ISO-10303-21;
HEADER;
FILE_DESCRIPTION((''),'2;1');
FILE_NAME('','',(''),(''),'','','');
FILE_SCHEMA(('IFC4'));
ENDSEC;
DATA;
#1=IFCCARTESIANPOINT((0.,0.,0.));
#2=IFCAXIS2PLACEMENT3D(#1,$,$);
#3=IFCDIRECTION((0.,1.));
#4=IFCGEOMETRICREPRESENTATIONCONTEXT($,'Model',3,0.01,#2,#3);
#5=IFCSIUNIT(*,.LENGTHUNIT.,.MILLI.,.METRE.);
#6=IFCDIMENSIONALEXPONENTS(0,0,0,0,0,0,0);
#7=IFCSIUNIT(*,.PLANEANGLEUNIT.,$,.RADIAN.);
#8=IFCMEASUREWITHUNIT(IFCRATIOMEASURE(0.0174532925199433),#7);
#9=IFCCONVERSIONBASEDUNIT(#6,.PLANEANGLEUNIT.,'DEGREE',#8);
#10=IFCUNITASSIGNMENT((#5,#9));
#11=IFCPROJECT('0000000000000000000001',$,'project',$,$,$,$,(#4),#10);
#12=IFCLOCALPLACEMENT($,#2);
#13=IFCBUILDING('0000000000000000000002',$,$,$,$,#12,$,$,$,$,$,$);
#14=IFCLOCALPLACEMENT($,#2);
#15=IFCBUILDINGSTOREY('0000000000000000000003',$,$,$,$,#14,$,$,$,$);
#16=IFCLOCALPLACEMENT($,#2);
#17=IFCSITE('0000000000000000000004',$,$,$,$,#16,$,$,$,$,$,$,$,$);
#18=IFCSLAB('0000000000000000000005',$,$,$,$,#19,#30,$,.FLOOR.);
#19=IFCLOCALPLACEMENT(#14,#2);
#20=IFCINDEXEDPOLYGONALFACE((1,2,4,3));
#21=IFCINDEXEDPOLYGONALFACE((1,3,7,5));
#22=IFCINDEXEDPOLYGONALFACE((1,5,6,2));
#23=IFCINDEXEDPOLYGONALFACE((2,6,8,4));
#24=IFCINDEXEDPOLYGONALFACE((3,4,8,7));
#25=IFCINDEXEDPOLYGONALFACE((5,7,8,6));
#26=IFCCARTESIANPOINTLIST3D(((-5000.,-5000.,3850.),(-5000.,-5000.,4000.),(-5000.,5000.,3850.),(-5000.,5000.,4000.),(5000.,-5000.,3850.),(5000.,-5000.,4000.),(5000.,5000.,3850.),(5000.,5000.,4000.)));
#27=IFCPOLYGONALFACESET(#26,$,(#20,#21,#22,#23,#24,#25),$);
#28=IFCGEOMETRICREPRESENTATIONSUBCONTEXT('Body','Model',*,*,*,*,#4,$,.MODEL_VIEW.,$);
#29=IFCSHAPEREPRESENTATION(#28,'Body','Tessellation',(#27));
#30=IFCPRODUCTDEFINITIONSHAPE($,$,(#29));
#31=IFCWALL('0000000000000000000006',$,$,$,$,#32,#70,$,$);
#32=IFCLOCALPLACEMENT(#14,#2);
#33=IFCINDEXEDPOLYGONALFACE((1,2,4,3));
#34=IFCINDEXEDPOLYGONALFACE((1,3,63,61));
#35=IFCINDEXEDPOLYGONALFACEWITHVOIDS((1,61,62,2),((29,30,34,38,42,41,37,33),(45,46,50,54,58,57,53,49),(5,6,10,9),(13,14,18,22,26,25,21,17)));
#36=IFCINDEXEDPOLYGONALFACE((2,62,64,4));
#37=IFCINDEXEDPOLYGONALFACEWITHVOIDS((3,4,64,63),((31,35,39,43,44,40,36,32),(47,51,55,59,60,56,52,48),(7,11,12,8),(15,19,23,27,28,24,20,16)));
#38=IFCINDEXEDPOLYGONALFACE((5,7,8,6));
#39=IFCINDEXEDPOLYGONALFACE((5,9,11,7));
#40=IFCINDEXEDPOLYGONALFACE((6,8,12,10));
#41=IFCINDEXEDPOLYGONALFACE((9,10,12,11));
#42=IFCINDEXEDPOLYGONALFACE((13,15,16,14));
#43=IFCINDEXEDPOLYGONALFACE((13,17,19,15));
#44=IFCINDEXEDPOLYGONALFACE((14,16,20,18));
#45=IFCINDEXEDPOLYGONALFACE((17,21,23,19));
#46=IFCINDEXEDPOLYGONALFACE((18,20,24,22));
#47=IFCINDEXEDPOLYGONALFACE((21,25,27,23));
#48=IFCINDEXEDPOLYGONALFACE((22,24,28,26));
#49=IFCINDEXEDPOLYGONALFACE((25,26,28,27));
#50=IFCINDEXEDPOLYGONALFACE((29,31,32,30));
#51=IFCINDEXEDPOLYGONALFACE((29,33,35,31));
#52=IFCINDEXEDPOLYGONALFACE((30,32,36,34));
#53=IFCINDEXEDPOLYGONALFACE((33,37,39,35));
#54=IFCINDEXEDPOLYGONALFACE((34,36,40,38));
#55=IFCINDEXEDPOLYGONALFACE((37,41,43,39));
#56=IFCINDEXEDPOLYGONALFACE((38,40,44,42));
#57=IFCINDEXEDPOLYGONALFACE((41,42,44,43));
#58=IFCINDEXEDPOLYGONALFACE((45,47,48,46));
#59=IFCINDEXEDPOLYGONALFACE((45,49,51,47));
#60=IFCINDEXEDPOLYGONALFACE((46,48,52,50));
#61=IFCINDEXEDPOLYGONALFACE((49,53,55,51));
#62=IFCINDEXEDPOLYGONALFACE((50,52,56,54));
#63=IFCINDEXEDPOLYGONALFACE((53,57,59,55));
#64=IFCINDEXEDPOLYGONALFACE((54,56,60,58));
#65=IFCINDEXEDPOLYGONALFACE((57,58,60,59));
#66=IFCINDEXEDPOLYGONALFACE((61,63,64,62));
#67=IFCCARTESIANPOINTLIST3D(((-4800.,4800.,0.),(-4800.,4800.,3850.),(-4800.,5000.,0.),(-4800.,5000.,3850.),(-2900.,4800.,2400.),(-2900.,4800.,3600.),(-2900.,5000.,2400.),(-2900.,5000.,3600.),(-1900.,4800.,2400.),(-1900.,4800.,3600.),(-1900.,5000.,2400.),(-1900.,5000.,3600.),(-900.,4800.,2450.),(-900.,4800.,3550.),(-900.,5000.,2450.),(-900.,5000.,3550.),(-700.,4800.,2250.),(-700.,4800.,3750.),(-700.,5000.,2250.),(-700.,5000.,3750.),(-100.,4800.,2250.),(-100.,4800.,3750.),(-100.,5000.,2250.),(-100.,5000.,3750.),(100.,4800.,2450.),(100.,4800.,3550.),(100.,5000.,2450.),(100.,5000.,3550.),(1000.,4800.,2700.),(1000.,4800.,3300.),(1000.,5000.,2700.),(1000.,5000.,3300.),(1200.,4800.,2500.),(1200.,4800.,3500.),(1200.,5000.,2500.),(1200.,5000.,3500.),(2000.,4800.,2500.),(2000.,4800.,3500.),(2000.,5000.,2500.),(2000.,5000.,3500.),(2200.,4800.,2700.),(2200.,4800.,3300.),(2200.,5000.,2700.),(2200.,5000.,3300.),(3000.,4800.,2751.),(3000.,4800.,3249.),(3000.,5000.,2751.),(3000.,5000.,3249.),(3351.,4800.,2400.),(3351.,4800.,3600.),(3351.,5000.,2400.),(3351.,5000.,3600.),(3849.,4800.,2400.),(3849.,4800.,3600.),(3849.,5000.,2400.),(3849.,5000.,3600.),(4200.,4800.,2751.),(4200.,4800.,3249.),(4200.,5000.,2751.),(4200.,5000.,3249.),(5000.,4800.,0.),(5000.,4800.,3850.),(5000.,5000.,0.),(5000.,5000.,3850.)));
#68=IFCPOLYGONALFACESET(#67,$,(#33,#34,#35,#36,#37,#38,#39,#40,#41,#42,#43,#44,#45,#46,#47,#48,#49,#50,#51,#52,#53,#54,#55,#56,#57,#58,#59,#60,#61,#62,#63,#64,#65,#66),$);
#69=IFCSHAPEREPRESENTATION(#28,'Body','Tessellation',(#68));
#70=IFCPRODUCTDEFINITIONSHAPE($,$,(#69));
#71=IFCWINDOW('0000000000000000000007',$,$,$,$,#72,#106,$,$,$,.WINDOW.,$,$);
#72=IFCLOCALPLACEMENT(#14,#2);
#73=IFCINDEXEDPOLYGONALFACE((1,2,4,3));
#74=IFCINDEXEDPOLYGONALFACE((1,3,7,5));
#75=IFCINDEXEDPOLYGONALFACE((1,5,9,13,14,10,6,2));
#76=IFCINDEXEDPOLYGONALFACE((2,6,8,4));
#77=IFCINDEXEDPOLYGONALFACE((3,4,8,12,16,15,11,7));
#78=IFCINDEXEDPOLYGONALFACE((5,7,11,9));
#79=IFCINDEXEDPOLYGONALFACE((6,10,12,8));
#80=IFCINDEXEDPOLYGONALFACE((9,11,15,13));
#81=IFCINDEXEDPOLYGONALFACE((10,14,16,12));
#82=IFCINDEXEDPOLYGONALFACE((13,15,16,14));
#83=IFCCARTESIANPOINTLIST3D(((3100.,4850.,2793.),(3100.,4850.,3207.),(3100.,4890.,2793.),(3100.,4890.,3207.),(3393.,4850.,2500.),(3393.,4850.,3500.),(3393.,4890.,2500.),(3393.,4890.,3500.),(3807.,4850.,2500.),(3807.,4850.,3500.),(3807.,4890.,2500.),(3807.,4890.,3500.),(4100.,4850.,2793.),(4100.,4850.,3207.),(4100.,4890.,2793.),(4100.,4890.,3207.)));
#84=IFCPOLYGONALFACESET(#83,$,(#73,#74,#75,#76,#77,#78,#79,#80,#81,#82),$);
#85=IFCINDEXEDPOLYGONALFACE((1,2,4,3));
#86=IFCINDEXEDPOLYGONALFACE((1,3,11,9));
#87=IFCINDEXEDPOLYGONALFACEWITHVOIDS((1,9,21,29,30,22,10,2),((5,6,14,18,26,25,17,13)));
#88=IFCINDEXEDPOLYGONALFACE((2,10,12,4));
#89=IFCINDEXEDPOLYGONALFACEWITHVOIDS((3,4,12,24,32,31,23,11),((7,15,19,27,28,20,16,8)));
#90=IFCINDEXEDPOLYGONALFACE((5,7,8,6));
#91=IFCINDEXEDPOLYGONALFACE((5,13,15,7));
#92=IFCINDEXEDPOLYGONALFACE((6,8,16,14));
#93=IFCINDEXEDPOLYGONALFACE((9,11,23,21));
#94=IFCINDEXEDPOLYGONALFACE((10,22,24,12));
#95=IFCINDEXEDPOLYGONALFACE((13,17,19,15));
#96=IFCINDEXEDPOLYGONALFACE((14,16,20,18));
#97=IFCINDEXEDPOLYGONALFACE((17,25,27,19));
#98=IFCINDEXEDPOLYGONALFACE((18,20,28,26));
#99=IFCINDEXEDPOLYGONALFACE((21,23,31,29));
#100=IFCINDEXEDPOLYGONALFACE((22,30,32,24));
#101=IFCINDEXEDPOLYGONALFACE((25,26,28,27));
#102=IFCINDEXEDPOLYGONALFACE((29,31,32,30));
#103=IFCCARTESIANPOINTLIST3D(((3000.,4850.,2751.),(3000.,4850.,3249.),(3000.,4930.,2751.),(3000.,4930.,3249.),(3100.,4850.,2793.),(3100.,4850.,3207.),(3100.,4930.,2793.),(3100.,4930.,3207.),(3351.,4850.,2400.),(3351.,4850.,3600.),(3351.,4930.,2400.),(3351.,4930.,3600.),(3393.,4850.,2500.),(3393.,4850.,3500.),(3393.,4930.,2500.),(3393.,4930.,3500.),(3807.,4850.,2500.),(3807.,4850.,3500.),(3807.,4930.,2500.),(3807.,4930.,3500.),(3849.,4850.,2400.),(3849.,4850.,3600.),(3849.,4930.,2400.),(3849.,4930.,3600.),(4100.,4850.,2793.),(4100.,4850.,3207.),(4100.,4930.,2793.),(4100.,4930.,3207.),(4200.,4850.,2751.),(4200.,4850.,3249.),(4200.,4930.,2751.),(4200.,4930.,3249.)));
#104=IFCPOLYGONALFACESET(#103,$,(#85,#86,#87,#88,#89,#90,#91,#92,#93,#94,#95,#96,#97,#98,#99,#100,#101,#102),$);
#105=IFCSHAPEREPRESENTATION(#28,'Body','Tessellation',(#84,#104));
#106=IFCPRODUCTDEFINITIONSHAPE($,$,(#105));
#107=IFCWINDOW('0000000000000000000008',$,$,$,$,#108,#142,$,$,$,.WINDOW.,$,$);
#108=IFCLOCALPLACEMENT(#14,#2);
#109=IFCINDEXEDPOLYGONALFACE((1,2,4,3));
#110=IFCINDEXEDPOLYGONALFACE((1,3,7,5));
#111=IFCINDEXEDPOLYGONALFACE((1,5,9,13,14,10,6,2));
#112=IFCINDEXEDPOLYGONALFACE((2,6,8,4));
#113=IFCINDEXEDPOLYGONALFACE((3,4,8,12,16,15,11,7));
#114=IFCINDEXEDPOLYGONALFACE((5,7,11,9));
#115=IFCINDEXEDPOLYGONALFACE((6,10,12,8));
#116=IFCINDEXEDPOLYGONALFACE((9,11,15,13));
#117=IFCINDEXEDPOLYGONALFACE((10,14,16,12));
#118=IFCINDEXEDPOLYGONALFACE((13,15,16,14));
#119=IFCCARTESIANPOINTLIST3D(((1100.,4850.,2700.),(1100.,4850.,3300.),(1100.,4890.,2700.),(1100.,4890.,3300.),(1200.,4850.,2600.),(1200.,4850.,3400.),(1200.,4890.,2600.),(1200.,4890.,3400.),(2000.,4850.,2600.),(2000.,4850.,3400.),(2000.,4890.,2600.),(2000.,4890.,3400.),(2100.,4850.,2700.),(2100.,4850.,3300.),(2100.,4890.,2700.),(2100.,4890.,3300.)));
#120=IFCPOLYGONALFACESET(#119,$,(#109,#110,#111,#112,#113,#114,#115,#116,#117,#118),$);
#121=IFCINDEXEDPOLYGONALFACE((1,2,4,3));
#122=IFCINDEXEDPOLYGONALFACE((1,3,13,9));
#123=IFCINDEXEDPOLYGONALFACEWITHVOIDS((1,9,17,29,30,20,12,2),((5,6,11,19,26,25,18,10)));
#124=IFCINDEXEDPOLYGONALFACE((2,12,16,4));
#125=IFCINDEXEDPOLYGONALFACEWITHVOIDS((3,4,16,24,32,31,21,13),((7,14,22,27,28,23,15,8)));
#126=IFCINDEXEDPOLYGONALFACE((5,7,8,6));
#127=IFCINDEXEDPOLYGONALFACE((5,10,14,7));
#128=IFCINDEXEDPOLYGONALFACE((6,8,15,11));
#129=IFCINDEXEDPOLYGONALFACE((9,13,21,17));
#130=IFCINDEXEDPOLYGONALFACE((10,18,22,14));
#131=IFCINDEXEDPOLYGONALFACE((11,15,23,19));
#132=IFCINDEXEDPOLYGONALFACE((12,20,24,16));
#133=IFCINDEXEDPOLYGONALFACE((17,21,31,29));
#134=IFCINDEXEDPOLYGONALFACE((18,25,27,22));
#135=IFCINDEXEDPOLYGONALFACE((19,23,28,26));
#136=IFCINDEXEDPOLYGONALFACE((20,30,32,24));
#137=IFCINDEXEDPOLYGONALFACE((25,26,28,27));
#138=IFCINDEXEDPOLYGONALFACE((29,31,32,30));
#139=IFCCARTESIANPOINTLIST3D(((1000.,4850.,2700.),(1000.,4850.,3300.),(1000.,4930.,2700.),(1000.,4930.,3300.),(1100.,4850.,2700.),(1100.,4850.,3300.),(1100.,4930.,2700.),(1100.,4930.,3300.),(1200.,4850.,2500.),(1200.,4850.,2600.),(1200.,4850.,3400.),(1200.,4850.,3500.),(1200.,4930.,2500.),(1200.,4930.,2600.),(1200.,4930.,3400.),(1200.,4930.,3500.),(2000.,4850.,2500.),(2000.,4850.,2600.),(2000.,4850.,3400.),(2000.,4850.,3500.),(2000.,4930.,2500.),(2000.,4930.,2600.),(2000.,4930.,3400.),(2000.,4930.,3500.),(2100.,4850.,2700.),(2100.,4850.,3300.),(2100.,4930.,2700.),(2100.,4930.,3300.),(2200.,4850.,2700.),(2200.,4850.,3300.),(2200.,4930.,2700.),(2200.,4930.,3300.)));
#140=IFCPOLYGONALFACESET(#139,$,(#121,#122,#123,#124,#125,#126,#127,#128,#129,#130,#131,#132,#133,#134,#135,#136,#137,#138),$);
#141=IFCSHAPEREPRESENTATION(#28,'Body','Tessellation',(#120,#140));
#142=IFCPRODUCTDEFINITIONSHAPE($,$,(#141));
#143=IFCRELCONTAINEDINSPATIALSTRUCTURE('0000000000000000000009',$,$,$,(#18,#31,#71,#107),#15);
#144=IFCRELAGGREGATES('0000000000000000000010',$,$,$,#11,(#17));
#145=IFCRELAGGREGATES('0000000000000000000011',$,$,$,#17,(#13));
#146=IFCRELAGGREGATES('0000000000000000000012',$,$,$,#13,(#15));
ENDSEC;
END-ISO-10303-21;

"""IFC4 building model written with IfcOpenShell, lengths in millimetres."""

from ifc_helpers import new_model, entity, si_unit, converted_unit, direction, frame, origin, origin_2d, place, context, subcontext, project, spatial, polyline, rectangle, outline, extrude, element, save


model = new_model("IFC4")

# Units and contexts
model_context = context("Model", 3, precision=0.01, world=origin(), true_north=direction((0.0, 1.0)))
body_context = subcontext(model_context, "Body", "Model", "MODEL_VIEW")
ifc_project = project(units=[si_unit("LENGTHUNIT", "METRE", prefix="MILLI"), converted_unit("PLANEANGLEUNIT", "DEGREE", entity("IfcRatioMeasure", 0.0174532925199433), si_unit("PLANEANGLEUNIT", "RADIAN"), dimensions=[0, 0, 0, 0, 0, 0, 0])], contexts=[model_context])

# Site, building, storey
site_placement = place(None, origin())
site = spatial("IfcSite", under=ifc_project, at=site_placement)
building_placement = place(None, origin())
building = spatial("IfcBuilding", under=site, at=building_placement)
storey_placement = place(None, origin())
storey = spatial("IfcBuildingStorey", under=building, at=storey_placement)

# Slab
slab_placement = place(storey_placement, frame((0.0, 0.0, 3850.0)))
element("IfcSlab", 1, at=slab_placement, inside=storey, PredefinedType="FLOOR", context=body_context, shape_type="SweptSolid", body=[
    extrude(rectangle(XDim=10000.0, YDim=10000.0, at=origin_2d()), origin(), (0.0, 0.0, 1.0), 150.0),
])

# Wall, openings
wall_1_placement = place(storey_placement, frame((100.0, 4900.0, 0.0), z_axis=(0.0, 0.0, 1.0), x_axis=(-1.0, 0.0, 0.0)))
wall_1 = element("IfcWall", 2, at=wall_1_placement, inside=storey, context=body_context, shape_type="SweptSolid", body=[
    extrude(rectangle(XDim=9800.0, YDim=200.0, at=origin_2d()), origin(), (0.0, 0.0, 1.0), 3850.0),
])
window_1_placement = place(wall_1_placement, frame((-3500.0, 50.0, 3000.0)))
opening_1_placement = place(window_1_placement, frame((0.0, 50.0, 0.0)))
element("IfcOpeningElement", 3, at=opening_1_placement, cuts=wall_1, context=body_context, shape_type="SweptSolid", body=[
    extrude(outline(polyline([(-600.0, -249.0), (-600.0, 249.0), (-249.0, 600.0), (249.0, 600.0), (600.0, 249.0), (600.0, -249.0), (249.0, -600.0), (-249.0, -600.0), (-600.0, -249.0)])), frame((0.0, 0.0, 0.0), z_axis=(0.0, -1.0, 0.0), x_axis=(1.0, 0.0, 0.0)), (0.0, 0.0, 1.0), 200.0),
])
window_2_placement = place(wall_1_placement, frame((-1500.0, 50.0, 3000.0)))
opening_2_placement = place(window_2_placement, frame((0.0, 50.0, 0.0)))
element("IfcOpeningElement", 4, at=opening_2_placement, cuts=wall_1, context=body_context, shape_type="SweptSolid", body=[
    extrude(outline(polyline([(-600.0, -300.0), (-600.0, 300.0), (-400.0, 500.0), (400.0, 500.0), (600.0, 300.0), (600.0, -300.0), (400.0, -500.0), (-400.0, -500.0), (-600.0, -300.0)])), frame((0.0, 0.0, 0.0), z_axis=(0.0, -1.0, 0.0), x_axis=(1.0, 0.0, 0.0)), (0.0, 0.0, 1.0), 200.0),
])
window_3_placement = place(wall_1_placement, frame((500.0, 50.0, 3000.0)))
opening_3_placement = place(window_3_placement, frame((0.0, 50.0, 0.0)))
element("IfcOpeningElement", 5, at=opening_3_placement, cuts=wall_1, context=body_context, shape_type="SweptSolid", body=[
    extrude(outline(polyline([(-500.0, -550.0), (-500.0, 550.0), (-300.0, 750.0), (300.0, 750.0), (500.0, 550.0), (500.0, -550.0), (300.0, -750.0), (-300.0, -750.0), (-500.0, -550.0)])), frame((0.0, 0.0, 0.0), z_axis=(0.0, -1.0, 0.0), x_axis=(1.0, 0.0, 0.0)), (0.0, 0.0, 1.0), 200.0),
])
window_4_placement = place(wall_1_placement, frame((2500.0, 50.0, 3000.0)))
opening_4_placement = place(window_4_placement, frame((0.0, 50.0, 0.0)))
element("IfcOpeningElement", 6, at=opening_4_placement, cuts=wall_1, context=body_context, shape_type="SweptSolid", body=[
    extrude(outline(polyline([(-500.0, -600.0), (-500.0, 600.0), (-500.0, 600.0), (500.0, 600.0), (500.0, 600.0), (500.0, -600.0), (500.0, -600.0), (-500.0, -600.0), (-500.0, -600.0)])), frame((0.0, 0.0, 0.0), z_axis=(0.0, -1.0, 0.0), x_axis=(1.0, 0.0, 0.0)), (0.0, 0.0, 1.0), 200.0),
])

# Windows
cartesian_point_1 = entity("IfcCartesianPoint", [-500.0, -207.0])
shared_polyline_1 = entity("IfcPolyline", [cartesian_point_1, entity("IfcCartesianPoint", [-500.0, 207.0]), entity("IfcCartesianPoint", [-207.0, 500.0]), entity("IfcCartesianPoint", [207.0, 500.0]), entity("IfcCartesianPoint", [500.0, 207.0]), entity("IfcCartesianPoint", [500.0, -207.0]), entity("IfcCartesianPoint", [207.0, -500.0]), entity("IfcCartesianPoint", [-207.0, -500.0]), cartesian_point_1])
cartesian_point_2 = entity("IfcCartesianPoint", [-600.0, -249.0])
element("IfcWindow", 7, at=window_1_placement, inside=storey, PredefinedType="WINDOW", context=body_context, shape_type="SweptSolid", body=[
    entity("IfcExtrudedAreaSolid", entity("IfcArbitraryClosedProfileDef", "AREA", None, shared_polyline_1), entity("IfcAxis2Placement3D", entity("IfcCartesianPoint", [0.0, 0.0, 0.0]), entity("IfcDirection", [0.0, -1.0, 0.0]), entity("IfcDirection", [1.0, 0.0, 0.0])), entity("IfcDirection", [0.0, 0.0, 1.0]), 40.0),
    entity("IfcExtrudedAreaSolid", entity("IfcArbitraryProfileDefWithVoids", "AREA", None, entity("IfcPolyline", [cartesian_point_2, entity("IfcCartesianPoint", [-600.0, 249.0]), entity("IfcCartesianPoint", [-249.0, 600.0]), entity("IfcCartesianPoint", [249.0, 600.0]), entity("IfcCartesianPoint", [600.0, 249.0]), entity("IfcCartesianPoint", [600.0, -249.0]), entity("IfcCartesianPoint", [249.0, -600.0]), entity("IfcCartesianPoint", [-249.0, -600.0]), cartesian_point_2]), [shared_polyline_1]), entity("IfcAxis2Placement3D", entity("IfcCartesianPoint", [0.0, 0.0, 0.0]), entity("IfcDirection", [0.0, -1.0, 0.0]), entity("IfcDirection", [1.0, 0.0, 0.0])), entity("IfcDirection", [0.0, 0.0, 1.0]), 80.0),
])
cartesian_point_3 = entity("IfcCartesianPoint", [-500.0, -300.0])
shared_polyline_2 = entity("IfcPolyline", [cartesian_point_3, entity("IfcCartesianPoint", [-500.0, 300.0]), entity("IfcCartesianPoint", [-400.0, 400.0]), entity("IfcCartesianPoint", [400.0, 400.0]), entity("IfcCartesianPoint", [500.0, 300.0]), entity("IfcCartesianPoint", [500.0, -300.0]), entity("IfcCartesianPoint", [400.0, -400.0]), entity("IfcCartesianPoint", [-400.0, -400.0]), cartesian_point_3])
cartesian_point_4 = entity("IfcCartesianPoint", [-600.0, -300.0])
element("IfcWindow", 8, at=window_2_placement, inside=storey, PredefinedType="WINDOW", context=body_context, shape_type="SweptSolid", body=[
    entity("IfcExtrudedAreaSolid", entity("IfcArbitraryClosedProfileDef", "AREA", None, shared_polyline_2), entity("IfcAxis2Placement3D", entity("IfcCartesianPoint", [0.0, 0.0, 0.0]), entity("IfcDirection", [0.0, -1.0, 0.0]), entity("IfcDirection", [1.0, 0.0, 0.0])), entity("IfcDirection", [0.0, 0.0, 1.0]), 40.0),
    entity("IfcExtrudedAreaSolid", entity("IfcArbitraryProfileDefWithVoids", "AREA", None, entity("IfcPolyline", [cartesian_point_4, entity("IfcCartesianPoint", [-600.0, 300.0]), entity("IfcCartesianPoint", [-400.0, 500.0]), entity("IfcCartesianPoint", [400.0, 500.0]), entity("IfcCartesianPoint", [600.0, 300.0]), entity("IfcCartesianPoint", [600.0, -300.0]), entity("IfcCartesianPoint", [400.0, -500.0]), entity("IfcCartesianPoint", [-400.0, -500.0]), cartesian_point_4]), [shared_polyline_2]), entity("IfcAxis2Placement3D", entity("IfcCartesianPoint", [0.0, 0.0, 0.0]), entity("IfcDirection", [0.0, -1.0, 0.0]), entity("IfcDirection", [1.0, 0.0, 0.0])), entity("IfcDirection", [0.0, 0.0, 1.0]), 80.0),
])

save(model, "model.ifc")
